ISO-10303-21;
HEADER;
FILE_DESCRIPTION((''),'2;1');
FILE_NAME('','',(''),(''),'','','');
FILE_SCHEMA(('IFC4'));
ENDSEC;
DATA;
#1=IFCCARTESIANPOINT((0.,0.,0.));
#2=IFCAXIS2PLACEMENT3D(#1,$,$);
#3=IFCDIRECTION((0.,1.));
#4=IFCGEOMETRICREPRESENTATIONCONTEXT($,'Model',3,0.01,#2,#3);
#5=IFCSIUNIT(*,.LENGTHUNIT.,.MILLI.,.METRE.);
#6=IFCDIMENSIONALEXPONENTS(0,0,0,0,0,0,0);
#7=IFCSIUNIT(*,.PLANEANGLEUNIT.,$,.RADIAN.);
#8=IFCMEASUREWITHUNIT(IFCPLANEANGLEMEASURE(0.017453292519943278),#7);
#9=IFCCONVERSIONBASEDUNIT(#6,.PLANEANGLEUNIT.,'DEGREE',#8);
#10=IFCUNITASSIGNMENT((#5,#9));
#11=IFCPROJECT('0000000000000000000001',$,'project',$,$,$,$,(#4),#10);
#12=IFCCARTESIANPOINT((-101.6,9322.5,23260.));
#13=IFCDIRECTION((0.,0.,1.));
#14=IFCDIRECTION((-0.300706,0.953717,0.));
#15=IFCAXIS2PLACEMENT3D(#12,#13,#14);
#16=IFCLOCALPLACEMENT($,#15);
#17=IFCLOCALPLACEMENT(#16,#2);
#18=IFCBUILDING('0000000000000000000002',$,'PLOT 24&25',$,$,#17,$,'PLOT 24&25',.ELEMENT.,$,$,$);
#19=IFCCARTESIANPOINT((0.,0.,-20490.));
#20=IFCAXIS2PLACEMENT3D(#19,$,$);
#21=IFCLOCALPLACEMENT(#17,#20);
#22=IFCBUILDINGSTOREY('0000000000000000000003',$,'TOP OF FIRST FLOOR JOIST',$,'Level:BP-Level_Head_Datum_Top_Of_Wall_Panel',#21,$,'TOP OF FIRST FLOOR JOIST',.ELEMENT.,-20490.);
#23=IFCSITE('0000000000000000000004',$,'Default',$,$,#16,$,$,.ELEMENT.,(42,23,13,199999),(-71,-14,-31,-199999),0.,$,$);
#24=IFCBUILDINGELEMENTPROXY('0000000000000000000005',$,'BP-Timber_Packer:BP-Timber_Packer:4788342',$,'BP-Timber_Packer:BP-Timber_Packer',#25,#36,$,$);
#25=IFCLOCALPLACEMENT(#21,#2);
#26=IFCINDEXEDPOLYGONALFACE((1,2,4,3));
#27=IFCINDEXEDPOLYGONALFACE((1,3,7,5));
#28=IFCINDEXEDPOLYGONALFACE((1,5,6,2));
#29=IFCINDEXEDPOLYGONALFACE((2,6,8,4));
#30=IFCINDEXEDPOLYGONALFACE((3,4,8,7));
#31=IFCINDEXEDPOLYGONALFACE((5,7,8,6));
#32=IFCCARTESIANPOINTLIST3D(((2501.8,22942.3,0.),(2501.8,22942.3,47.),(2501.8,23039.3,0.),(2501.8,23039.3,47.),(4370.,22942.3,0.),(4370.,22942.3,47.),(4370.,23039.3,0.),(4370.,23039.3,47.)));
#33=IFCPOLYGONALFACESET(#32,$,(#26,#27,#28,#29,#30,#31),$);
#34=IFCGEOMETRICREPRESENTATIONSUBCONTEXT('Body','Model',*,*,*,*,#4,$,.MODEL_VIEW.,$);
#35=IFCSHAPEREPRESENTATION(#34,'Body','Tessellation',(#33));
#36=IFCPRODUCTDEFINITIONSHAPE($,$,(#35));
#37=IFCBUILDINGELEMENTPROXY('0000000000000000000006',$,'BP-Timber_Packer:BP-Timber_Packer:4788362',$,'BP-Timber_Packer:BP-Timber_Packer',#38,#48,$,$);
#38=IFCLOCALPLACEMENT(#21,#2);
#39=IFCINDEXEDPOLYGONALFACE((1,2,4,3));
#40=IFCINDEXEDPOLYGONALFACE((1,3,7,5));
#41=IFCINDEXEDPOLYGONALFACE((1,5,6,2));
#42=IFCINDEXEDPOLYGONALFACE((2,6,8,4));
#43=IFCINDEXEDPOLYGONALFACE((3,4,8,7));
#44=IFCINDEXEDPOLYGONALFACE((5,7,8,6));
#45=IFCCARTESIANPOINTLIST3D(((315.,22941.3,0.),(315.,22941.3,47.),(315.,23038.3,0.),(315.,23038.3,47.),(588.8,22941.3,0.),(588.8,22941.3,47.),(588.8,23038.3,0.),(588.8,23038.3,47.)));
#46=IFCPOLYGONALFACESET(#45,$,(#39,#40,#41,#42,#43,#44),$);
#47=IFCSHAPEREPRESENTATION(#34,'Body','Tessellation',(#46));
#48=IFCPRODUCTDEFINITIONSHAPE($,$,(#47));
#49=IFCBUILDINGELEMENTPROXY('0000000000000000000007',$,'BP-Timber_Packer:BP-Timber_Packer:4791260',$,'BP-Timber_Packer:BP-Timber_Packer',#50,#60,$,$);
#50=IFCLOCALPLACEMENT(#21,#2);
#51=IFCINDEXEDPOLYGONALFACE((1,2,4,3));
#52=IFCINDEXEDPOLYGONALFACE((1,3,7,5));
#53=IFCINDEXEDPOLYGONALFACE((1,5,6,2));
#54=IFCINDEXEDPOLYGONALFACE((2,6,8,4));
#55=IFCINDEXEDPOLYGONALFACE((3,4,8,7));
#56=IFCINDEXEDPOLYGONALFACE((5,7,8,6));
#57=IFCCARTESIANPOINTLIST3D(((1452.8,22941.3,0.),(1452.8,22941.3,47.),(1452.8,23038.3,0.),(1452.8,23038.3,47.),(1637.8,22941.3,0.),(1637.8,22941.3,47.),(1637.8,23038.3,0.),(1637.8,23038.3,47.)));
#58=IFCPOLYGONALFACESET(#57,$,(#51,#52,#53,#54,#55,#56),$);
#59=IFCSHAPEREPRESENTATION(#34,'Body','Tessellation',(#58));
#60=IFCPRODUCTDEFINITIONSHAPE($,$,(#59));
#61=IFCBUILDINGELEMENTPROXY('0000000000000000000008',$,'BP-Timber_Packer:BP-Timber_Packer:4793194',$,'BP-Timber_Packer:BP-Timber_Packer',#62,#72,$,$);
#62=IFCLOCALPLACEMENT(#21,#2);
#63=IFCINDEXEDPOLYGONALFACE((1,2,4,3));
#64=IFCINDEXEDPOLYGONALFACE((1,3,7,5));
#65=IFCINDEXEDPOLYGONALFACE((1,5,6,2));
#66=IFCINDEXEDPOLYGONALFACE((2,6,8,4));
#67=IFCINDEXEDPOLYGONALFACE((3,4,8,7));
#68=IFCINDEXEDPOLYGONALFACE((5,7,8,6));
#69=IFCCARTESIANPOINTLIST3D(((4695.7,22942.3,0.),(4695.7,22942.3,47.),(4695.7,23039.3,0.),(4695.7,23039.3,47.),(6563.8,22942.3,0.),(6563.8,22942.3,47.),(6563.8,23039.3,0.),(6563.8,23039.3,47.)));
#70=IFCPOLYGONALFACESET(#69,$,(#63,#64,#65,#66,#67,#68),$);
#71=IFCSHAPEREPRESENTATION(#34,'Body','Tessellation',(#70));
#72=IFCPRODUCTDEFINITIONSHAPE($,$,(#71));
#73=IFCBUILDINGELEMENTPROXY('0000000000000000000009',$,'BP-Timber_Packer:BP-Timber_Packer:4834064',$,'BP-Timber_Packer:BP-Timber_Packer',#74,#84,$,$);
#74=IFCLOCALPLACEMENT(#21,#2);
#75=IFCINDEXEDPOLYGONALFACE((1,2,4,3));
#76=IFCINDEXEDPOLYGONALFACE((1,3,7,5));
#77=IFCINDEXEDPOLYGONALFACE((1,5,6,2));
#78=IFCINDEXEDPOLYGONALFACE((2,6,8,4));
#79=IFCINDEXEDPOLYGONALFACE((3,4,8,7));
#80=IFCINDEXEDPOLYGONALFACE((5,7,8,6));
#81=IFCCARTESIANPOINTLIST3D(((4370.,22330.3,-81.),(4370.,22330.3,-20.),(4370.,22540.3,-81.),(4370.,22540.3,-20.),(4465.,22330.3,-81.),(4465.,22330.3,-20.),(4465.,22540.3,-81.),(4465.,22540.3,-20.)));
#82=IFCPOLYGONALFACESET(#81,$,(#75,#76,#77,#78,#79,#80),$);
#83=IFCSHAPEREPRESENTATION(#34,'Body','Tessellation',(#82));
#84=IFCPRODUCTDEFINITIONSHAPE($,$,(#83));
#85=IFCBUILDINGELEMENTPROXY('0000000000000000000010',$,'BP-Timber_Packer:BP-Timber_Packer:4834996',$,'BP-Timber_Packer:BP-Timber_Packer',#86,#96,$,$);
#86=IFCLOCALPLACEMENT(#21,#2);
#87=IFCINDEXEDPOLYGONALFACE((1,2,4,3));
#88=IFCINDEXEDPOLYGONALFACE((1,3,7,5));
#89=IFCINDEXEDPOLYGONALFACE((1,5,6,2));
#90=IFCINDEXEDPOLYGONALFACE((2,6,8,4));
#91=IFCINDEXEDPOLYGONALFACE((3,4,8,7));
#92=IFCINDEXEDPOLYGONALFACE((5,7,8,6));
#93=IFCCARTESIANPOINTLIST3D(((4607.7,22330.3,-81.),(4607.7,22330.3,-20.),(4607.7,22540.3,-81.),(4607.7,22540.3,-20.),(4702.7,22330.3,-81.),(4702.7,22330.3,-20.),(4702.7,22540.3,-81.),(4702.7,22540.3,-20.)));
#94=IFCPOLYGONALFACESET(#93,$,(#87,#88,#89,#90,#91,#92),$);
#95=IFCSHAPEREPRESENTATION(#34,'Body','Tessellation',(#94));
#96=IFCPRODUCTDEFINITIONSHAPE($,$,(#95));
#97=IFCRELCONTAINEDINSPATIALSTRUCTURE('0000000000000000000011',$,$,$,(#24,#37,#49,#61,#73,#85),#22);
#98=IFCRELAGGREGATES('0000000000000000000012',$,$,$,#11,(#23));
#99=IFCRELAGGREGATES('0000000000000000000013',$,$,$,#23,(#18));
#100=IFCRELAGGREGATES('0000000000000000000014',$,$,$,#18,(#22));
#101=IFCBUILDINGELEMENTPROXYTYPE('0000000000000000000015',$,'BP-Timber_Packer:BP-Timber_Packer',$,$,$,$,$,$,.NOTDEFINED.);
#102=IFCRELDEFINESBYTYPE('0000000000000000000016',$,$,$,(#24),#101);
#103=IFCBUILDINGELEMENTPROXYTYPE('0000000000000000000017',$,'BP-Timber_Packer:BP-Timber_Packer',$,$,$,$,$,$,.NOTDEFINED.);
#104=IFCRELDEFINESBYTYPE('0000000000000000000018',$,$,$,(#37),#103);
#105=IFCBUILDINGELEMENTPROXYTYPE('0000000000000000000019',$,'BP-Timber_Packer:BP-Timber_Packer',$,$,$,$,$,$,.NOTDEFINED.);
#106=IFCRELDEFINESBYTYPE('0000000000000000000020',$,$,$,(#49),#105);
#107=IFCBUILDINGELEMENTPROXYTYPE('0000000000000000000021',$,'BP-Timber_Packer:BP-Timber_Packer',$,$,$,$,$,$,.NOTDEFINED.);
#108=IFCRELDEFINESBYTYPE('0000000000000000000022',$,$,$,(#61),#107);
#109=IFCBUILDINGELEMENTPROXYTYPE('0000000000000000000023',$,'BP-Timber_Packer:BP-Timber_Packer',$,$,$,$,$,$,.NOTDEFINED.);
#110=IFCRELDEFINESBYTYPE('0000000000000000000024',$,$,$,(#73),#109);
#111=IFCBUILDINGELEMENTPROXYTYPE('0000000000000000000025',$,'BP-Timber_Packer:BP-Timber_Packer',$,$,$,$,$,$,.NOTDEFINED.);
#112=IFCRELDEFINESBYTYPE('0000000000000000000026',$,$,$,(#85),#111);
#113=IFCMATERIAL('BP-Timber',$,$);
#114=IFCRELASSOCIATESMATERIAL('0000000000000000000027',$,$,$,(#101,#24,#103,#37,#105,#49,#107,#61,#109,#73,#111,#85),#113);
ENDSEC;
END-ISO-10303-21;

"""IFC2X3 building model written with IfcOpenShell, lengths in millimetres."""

from ifc_helpers import new_model, entity, si_unit, converted_unit, direction, frame, origin, origin_2d_with_axis, place, context, subcontext, project, spatial, rectangle, extrude, source, transform, mapped, material, type_object, type_shapes, element, save


model = new_model("IFC2X3")

# Units and contexts
model_context = context("Model", 3, precision=0.01, world=origin(), true_north=direction((0.0, 1.0)))
body_context = subcontext(model_context, "Body", "Model", "MODEL_VIEW")
ifc_project = project(units=[si_unit("LENGTHUNIT", "METRE", prefix="MILLI"), converted_unit("PLANEANGLEUNIT", "DEGREE", entity("IfcPlaneAngleMeasure", 0.017453292519943278), si_unit("PLANEANGLEUNIT", "RADIAN"), dimensions=[0, 0, 0, 0, 0, 0, 0])], contexts=[model_context])

# Site, building, storey
site_placement = place(None, frame((-101.6, 9322.5, 23260.0), z_axis=(0.0, 0.0, 1.0), x_axis=(-0.300706, 0.953717, 0.0)))
site = spatial("IfcSite", under=ifc_project, at=site_placement, Name="Default", CompositionType="ELEMENT", RefLatitude=(42, 23, 13, 199999), RefLongitude=(-71, -14, -31, -199999), RefElevation=0.0)
building_placement = place(site_placement, origin())
building = spatial("IfcBuilding", under=site, at=building_placement, Name="PLOT 24&25", LongName="PLOT 24&25", CompositionType="ELEMENT")
storey_placement = place(building_placement, frame((0.0, 0.0, -20490.0)))
storey = spatial("IfcBuildingStorey", under=building, at=storey_placement, Name="TOP OF FIRST FLOOR JOIST", ObjectType="Level:BP-Level_Head_Datum_Top_Of_Wall_Panel", LongName="TOP OF FIRST FLOOR JOIST", CompositionType="ELEMENT", Elevation=-20490.0)

# Building element proxies
ifc_material_1 = material(Name="BP-Timber")
building_element_proxy_type_1 = type_object("IfcBuildingElementProxyType", Name="BP-Timber_Packer:BP-Timber_Packer", PredefinedType="NOTDEFINED", material=ifc_material_1)
shared_shape_1 = source(origin(), body_context, "Body", "SweptSolid", [
    extrude(rectangle(XDim=1868.2, YDim=97.0, at=origin_2d_with_axis()), frame((0.0, 0.0, 0.0), z_axis=(0.0, 0.0, 1.0), x_axis=(-1.0, 0.0, 0.0)), (0.0, 0.0, 1.0), 47.0),
])
type_shapes(building_element_proxy_type_1, [shared_shape_1])
proxy_1_placement = place(storey_placement, frame((3435.9, 22990.8, 0.0)))
element("IfcBuildingElementProxy", 1, at=proxy_1_placement, inside=storey, type_object=building_element_proxy_type_1, material=ifc_material_1, Name="BP-Timber_Packer:BP-Timber_Packer:4788342", ObjectType="BP-Timber_Packer:BP-Timber_Packer", context=body_context, shape_type="MappedRepresentation", body=[
    mapped(shared_shape_1, transform((0.0, 0.0, 0.0), scale=1.0)),
])
building_element_proxy_type_2 = type_object("IfcBuildingElementProxyType", Name="BP-Timber_Packer:BP-Timber_Packer", PredefinedType="NOTDEFINED", material=ifc_material_1)
shared_shape_2 = source(origin(), body_context, "Body", "SweptSolid", [
    extrude(rectangle(XDim=273.8, YDim=97.0, at=origin_2d_with_axis()), frame((0.0, 0.0, 0.0), z_axis=(0.0, 0.0, 1.0), x_axis=(-1.0, 0.0, 0.0)), (0.0, 0.0, 1.0), 47.0),
])
type_shapes(building_element_proxy_type_2, [shared_shape_2])
proxy_2_placement = place(storey_placement, frame((451.9, 22989.8, 0.0)))
element("IfcBuildingElementProxy", 2, at=proxy_2_placement, inside=storey, type_object=building_element_proxy_type_2, material=ifc_material_1, Name="BP-Timber_Packer:BP-Timber_Packer:4788362", ObjectType="BP-Timber_Packer:BP-Timber_Packer", context=body_context, shape_type="MappedRepresentation", body=[
    mapped(shared_shape_2, transform((0.0, 0.0, 0.0), scale=1.0)),
])
building_element_proxy_type_3 = type_object("IfcBuildingElementProxyType", Name="BP-Timber_Packer:BP-Timber_Packer", PredefinedType="NOTDEFINED", material=ifc_material_1)
shared_shape_3 = source(origin(), body_context, "Body", "SweptSolid", [
    extrude(rectangle(XDim=185.0, YDim=97.0, at=origin_2d_with_axis()), frame((0.0, 0.0, 0.0), z_axis=(0.0, 0.0, 1.0), x_axis=(-1.0, 0.0, 0.0)), (0.0, 0.0, 1.0), 47.0),
])
type_shapes(building_element_proxy_type_3, [shared_shape_3])
proxy_3_placement = place(storey_placement, frame((1545.3, 22989.8, 0.0)))
element("IfcBuildingElementProxy", 3, at=proxy_3_placement, inside=storey, type_object=building_element_proxy_type_3, material=ifc_material_1, Name="BP-Timber_Packer:BP-Timber_Packer:4791260", ObjectType="BP-Timber_Packer:BP-Timber_Packer", context=body_context, shape_type="MappedRepresentation", body=[
    mapped(shared_shape_3, transform((0.0, 0.0, 0.0), scale=1.0)),
])
building_element_proxy_type_4 = type_object("IfcBuildingElementProxyType", Name="BP-Timber_Packer:BP-Timber_Packer", PredefinedType="NOTDEFINED", material=ifc_material_1)
shared_shape_4 = source(origin(), body_context, "Body", "SweptSolid", [
    extrude(rectangle(XDim=97.0, YDim=1868.2, at=origin_2d_with_axis()), frame((0.0, 0.0, 0.0), z_axis=(0.0, 0.0, 1.0), x_axis=(0.0, 1.0, 0.0)), (0.0, 0.0, 1.0), 47.0),
])
type_shapes(building_element_proxy_type_4, [shared_shape_4])
proxy_4_placement = place(storey_placement, frame((5629.8, 22990.8, 0.0), z_axis=(0.0, 0.0, 1.0), x_axis=(-1.0, 0.0, 0.0)))
element("IfcBuildingElementProxy", 4, at=proxy_4_placement, inside=storey, type_object=building_element_proxy_type_4, material=ifc_material_1, Name="BP-Timber_Packer:BP-Timber_Packer:4793194", ObjectType="BP-Timber_Packer:BP-Timber_Packer", context=body_context, shape_type="MappedRepresentation", body=[
    mapped(shared_shape_4, transform((0.0, 0.0, 0.0), scale=1.0)),
])
building_element_proxy_type_5 = type_object("IfcBuildingElementProxyType", Name="BP-Timber_Packer:BP-Timber_Packer", PredefinedType="NOTDEFINED", material=ifc_material_1)
shared_shape_5 = source(origin(), body_context, "Body", "SweptSolid", [
    extrude(rectangle(XDim=210.0, YDim=95.0, at=origin_2d_with_axis()), frame((0.0, 0.0, 0.0), z_axis=(0.0, 0.0, 1.0), x_axis=(-1.0, 0.0, 0.0)), (0.0, 0.0, 1.0), 61.0),
])
type_shapes(building_element_proxy_type_5, [shared_shape_5])
proxy_5_placement = place(storey_placement, frame((4417.5, 22435.3, -81.0), z_axis=(0.0, 0.0, 1.0), x_axis=(0.0, 1.0, 0.0)))
element("IfcBuildingElementProxy", 5, at=proxy_5_placement, inside=storey, type_object=building_element_proxy_type_5, material=ifc_material_1, Name="BP-Timber_Packer:BP-Timber_Packer:4834064", ObjectType="BP-Timber_Packer:BP-Timber_Packer", context=body_context, shape_type="MappedRepresentation", body=[
    mapped(shared_shape_5, transform((0.0, 0.0, 0.0), scale=1.0)),
])
building_element_proxy_type_6 = type_object("IfcBuildingElementProxyType", Name="BP-Timber_Packer:BP-Timber_Packer", PredefinedType="NOTDEFINED", material=ifc_material_1)
shared_shape_6 = source(origin(), body_context, "Body", "SweptSolid", [
    extrude(rectangle(XDim=95.0, YDim=210.0, at=origin_2d_with_axis()), frame((0.0, 0.0, 0.0), z_axis=(0.0, 0.0, 1.0), x_axis=(0.0, 1.0, 0.0)), (0.0, 0.0, 1.0), 61.0),
])
type_shapes(building_element_proxy_type_6, [shared_shape_6])
proxy_6_placement = place(storey_placement, frame((4655.2, 22435.3, -81.0), z_axis=(0.0, 0.0, 1.0), x_axis=(0.0, 1.0, 0.0)))
element("IfcBuildingElementProxy", 6, at=proxy_6_placement, inside=storey, type_object=building_element_proxy_type_6, material=ifc_material_1, Name="BP-Timber_Packer:BP-Timber_Packer:4834996", ObjectType="BP-Timber_Packer:BP-Timber_Packer", context=body_context, shape_type="MappedRepresentation", body=[
    mapped(shared_shape_6, transform((0.0, 0.0, 0.0), scale=1.0)),
])

save(model, "model.ifc")
